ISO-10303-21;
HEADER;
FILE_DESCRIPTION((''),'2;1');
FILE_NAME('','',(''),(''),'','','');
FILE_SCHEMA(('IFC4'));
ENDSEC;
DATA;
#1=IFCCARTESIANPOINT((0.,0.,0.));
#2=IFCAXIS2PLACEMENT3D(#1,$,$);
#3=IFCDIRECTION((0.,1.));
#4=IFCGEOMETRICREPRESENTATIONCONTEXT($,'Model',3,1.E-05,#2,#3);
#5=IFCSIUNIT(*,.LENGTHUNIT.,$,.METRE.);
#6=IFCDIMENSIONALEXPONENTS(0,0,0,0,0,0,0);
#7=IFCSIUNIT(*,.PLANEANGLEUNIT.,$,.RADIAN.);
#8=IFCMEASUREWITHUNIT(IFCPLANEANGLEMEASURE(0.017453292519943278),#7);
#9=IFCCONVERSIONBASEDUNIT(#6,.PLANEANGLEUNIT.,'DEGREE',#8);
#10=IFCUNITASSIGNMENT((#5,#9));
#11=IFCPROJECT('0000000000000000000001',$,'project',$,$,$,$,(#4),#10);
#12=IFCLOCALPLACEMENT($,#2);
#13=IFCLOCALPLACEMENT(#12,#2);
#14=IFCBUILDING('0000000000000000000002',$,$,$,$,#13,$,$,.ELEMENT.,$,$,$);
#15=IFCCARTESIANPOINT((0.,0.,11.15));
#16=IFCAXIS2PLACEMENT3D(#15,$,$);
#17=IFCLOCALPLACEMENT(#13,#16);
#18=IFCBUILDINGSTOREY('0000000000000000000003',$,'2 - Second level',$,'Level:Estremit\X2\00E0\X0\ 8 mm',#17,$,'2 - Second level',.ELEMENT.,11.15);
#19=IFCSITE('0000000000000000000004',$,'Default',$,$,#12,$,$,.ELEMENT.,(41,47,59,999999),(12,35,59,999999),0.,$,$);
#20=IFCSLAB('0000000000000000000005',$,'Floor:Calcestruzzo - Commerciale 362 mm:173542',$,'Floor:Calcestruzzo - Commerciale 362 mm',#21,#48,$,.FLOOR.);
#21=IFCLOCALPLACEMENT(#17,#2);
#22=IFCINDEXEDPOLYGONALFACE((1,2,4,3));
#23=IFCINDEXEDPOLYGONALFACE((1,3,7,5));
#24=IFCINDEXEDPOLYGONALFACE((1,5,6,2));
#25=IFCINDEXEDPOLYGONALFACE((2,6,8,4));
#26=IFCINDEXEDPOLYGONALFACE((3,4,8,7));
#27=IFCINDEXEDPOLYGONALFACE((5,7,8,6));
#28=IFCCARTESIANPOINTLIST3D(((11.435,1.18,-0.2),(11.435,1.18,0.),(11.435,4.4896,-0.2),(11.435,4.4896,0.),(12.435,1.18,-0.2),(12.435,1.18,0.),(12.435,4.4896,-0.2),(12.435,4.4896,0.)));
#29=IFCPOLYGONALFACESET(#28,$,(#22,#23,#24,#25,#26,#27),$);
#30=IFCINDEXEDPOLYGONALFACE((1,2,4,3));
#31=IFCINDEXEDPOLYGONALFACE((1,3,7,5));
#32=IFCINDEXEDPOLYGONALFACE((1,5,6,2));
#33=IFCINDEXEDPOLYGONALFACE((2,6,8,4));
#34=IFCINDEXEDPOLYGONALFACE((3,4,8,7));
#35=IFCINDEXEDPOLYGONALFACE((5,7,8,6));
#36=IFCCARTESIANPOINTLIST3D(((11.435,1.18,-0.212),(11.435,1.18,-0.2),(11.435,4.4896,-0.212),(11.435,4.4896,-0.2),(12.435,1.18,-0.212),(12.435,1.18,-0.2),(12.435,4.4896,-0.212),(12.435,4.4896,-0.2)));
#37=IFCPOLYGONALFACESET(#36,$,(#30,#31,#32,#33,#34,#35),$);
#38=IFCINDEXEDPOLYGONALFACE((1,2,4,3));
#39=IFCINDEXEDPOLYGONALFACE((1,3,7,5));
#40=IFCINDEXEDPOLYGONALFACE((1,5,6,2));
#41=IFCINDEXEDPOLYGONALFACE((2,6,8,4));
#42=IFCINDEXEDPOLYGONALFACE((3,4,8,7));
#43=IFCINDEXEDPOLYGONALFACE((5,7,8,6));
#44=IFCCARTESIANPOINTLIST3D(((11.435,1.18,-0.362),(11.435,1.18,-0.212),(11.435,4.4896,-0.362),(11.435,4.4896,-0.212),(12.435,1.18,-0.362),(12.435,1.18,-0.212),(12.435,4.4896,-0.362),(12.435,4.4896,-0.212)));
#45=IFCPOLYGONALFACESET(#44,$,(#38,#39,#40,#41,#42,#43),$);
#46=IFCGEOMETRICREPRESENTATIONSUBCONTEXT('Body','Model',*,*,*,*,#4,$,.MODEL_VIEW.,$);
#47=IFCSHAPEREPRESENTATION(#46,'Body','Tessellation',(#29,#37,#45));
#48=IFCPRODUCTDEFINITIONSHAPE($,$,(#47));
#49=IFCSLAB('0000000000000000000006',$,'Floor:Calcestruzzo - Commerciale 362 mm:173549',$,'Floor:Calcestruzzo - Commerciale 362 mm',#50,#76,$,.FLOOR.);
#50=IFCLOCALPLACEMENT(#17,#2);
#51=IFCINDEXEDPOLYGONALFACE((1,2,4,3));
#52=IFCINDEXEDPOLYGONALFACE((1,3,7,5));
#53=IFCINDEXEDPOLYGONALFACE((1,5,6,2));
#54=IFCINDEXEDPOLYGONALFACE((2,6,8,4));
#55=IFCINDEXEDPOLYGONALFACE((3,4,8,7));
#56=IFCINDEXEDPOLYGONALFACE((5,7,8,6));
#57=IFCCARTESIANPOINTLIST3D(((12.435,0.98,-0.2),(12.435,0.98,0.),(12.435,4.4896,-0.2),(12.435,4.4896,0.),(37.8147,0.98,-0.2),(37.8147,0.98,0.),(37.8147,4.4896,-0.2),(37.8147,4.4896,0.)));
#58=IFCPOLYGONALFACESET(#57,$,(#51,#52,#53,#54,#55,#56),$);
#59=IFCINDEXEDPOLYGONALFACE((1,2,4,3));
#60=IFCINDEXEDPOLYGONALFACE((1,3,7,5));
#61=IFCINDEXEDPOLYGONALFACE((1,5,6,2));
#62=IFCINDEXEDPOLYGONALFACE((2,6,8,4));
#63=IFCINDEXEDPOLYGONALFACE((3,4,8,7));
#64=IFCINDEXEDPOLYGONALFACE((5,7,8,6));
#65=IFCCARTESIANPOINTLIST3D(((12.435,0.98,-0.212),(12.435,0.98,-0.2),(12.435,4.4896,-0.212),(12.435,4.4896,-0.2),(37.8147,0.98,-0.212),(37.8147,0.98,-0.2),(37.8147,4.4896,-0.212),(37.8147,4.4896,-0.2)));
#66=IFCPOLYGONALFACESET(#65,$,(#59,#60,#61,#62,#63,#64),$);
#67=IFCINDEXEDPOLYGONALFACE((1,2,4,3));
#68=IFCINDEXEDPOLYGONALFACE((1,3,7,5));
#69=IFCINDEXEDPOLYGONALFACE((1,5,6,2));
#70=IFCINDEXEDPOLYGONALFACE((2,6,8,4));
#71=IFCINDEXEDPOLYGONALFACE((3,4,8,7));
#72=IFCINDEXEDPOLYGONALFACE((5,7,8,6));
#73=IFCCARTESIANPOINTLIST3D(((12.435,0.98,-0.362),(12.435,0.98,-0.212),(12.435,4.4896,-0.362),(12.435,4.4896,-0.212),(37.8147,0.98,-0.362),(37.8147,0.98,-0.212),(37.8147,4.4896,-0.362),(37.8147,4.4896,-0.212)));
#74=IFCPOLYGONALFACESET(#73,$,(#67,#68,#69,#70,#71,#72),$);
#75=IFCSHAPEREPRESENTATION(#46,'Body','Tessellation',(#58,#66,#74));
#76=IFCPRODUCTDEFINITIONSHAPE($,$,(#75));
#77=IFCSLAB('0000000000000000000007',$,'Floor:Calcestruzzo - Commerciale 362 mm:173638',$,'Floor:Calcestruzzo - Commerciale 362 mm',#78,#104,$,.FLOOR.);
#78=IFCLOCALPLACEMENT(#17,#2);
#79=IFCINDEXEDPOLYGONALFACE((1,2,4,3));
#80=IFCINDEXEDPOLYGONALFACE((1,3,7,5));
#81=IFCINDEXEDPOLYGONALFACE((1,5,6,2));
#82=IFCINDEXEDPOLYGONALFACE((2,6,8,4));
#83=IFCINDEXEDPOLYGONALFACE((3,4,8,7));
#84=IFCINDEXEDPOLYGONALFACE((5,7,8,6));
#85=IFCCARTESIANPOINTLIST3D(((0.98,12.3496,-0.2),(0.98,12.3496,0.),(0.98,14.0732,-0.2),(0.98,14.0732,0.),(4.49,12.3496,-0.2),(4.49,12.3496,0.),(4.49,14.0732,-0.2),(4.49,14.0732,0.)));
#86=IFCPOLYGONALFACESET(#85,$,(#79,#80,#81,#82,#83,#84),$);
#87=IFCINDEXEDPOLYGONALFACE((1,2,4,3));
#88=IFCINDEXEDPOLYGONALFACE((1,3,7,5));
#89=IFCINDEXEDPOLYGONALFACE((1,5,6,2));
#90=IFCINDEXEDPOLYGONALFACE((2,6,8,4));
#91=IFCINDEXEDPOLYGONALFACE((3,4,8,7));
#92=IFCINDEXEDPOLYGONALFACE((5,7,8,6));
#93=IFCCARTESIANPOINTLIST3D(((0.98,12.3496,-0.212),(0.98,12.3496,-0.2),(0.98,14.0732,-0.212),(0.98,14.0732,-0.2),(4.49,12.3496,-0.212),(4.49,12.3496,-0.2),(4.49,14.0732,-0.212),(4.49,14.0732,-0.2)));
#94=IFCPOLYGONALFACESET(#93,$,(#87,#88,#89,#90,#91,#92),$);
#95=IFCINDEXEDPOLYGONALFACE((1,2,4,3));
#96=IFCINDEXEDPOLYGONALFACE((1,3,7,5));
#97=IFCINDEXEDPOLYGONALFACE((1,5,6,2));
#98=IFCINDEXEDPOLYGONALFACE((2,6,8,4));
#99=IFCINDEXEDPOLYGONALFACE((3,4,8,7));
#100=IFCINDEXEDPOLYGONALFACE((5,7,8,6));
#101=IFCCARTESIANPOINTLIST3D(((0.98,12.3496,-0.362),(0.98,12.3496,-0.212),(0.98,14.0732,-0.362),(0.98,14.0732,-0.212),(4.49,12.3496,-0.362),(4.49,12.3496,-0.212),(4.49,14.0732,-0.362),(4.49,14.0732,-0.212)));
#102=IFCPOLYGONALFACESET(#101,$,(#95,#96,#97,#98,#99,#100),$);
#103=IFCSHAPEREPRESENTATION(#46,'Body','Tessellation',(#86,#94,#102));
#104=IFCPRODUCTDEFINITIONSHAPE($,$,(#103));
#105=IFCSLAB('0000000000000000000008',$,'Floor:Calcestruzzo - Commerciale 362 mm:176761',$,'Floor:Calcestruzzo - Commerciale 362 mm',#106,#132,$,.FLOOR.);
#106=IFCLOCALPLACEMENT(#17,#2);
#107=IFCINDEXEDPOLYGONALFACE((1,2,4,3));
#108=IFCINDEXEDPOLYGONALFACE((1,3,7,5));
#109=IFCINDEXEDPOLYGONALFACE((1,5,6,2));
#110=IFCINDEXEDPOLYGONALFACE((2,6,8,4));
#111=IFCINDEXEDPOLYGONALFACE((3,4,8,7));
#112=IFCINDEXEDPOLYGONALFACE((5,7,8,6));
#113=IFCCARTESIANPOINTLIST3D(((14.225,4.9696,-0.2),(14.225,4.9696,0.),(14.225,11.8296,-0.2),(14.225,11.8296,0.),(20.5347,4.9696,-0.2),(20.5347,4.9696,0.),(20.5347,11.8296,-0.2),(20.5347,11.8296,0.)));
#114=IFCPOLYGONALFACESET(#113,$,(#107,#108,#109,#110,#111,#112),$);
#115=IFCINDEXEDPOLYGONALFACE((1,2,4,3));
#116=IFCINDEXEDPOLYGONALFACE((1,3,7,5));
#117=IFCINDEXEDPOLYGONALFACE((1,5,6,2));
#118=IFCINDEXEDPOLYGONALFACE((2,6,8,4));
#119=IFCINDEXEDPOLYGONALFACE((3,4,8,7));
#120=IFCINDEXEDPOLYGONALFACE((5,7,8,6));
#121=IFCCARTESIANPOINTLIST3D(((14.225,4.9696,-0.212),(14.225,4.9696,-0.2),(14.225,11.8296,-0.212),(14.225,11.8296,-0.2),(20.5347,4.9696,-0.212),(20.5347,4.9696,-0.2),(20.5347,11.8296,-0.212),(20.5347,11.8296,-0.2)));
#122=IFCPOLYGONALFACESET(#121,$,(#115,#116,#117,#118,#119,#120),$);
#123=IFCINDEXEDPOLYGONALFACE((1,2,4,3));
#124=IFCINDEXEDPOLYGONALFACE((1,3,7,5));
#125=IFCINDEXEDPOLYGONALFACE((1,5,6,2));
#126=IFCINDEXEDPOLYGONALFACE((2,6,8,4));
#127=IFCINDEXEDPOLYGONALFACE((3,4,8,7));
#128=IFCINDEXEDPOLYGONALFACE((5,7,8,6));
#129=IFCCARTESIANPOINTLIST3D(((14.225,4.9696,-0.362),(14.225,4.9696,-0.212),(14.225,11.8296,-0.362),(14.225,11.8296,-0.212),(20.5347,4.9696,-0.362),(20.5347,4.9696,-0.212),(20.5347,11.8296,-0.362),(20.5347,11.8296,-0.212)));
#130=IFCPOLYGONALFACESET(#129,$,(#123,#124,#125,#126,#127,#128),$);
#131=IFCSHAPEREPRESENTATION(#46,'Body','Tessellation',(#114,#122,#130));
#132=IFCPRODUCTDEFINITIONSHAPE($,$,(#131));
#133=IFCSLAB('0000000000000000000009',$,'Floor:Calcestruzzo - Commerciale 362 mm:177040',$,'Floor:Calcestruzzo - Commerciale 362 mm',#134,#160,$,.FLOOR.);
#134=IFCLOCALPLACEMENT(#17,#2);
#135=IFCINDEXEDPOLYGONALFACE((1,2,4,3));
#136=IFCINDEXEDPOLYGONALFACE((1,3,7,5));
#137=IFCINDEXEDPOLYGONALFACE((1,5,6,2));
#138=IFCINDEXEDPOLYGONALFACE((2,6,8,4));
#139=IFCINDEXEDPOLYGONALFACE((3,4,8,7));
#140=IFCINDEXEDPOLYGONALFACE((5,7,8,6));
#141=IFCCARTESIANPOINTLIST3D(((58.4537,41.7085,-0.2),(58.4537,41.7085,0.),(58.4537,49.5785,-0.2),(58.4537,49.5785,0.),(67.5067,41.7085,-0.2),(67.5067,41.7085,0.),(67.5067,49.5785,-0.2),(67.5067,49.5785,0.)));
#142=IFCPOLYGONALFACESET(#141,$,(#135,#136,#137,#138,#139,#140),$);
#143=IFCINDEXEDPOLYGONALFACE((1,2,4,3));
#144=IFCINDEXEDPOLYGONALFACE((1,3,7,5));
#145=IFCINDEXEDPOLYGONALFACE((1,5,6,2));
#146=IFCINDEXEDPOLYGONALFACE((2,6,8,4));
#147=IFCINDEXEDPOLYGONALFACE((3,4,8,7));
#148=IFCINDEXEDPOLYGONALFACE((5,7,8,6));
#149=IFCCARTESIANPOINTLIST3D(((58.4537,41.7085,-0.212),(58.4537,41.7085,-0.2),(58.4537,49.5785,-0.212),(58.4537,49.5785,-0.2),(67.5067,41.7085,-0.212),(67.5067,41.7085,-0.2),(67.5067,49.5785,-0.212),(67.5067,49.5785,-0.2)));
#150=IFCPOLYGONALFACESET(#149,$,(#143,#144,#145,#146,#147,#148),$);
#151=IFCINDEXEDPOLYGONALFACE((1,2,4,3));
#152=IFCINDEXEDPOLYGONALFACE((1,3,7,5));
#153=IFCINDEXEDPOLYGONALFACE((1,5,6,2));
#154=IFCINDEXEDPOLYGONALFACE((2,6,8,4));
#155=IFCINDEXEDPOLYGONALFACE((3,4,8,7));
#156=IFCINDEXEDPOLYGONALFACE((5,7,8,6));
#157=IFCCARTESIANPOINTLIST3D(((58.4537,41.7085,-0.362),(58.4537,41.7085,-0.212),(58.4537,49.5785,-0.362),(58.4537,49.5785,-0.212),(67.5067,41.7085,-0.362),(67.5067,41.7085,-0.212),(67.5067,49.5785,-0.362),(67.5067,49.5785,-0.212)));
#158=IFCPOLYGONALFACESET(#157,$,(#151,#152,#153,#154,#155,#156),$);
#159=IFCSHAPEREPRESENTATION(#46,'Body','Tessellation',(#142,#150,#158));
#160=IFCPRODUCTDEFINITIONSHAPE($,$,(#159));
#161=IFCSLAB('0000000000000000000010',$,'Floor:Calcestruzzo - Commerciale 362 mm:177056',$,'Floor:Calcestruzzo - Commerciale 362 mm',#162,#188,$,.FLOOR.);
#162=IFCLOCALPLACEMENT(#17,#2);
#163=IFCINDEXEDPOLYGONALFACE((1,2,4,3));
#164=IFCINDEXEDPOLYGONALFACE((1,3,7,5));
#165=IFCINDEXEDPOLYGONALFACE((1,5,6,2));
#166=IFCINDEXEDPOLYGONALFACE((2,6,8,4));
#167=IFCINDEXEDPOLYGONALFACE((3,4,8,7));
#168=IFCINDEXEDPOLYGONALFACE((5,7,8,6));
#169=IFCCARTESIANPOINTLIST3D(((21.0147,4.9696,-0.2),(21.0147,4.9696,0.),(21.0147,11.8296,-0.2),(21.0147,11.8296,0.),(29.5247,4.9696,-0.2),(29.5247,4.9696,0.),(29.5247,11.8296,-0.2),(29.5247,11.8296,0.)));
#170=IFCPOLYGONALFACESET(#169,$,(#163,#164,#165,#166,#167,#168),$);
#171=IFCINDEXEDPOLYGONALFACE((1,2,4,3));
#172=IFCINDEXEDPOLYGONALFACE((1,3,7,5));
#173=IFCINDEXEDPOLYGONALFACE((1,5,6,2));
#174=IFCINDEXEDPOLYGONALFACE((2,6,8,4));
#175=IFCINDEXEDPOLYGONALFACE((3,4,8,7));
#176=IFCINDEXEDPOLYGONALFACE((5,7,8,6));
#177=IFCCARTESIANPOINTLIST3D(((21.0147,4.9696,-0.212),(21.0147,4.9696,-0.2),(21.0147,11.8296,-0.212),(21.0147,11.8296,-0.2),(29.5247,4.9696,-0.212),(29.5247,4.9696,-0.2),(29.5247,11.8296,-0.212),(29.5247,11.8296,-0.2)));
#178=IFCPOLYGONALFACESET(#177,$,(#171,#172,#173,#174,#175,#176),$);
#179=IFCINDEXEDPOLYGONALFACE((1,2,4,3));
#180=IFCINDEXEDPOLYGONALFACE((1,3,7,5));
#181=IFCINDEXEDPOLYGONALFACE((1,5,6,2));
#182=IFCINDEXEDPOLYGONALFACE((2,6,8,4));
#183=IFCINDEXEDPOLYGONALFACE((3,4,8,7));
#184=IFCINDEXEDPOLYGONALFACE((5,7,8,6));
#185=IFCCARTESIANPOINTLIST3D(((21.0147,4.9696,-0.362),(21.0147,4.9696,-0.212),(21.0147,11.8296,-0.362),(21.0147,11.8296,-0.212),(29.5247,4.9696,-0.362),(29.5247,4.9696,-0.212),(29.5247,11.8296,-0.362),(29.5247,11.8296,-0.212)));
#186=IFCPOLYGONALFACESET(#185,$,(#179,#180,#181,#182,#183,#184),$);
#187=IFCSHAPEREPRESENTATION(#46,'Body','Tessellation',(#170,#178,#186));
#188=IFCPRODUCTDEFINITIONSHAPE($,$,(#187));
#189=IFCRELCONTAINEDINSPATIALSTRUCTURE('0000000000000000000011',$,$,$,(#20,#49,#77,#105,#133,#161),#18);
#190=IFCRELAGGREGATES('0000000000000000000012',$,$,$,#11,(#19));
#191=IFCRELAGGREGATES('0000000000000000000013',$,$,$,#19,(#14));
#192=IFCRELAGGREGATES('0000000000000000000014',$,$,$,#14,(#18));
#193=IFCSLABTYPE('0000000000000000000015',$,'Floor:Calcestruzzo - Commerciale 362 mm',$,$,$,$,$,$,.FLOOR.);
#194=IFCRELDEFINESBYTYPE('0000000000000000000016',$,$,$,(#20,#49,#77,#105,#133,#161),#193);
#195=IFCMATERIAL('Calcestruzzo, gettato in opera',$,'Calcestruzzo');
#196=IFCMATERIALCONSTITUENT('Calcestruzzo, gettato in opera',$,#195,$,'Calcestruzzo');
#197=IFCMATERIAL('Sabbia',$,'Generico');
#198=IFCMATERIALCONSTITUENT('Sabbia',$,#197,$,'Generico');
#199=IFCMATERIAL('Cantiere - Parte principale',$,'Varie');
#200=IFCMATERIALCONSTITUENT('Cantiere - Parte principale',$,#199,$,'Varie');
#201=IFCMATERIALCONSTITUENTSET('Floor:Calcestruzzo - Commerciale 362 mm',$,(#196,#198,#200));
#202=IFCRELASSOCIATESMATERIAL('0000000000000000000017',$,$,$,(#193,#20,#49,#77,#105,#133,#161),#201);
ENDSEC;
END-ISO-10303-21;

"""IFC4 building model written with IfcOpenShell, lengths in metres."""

from ifc_helpers import new_model, entity, si_unit, converted_unit, direction, frame, origin, place, context, subcontext, project, spatial, indexed_curve, outline, extrude, material, constituent, constituent_set, type_object, element, save


model = new_model("IFC4")

# Units and contexts
model_context = context("Model", 3, precision=1e-05, world=origin(), true_north=direction((0.0, 1.0)))
body_context = subcontext(model_context, "Body", "Model", "MODEL_VIEW")
ifc_project = project(units=[si_unit("LENGTHUNIT", "METRE"), converted_unit("PLANEANGLEUNIT", "DEGREE", entity("IfcPlaneAngleMeasure", 0.017453292519943278), si_unit("PLANEANGLEUNIT", "RADIAN"), dimensions=[0, 0, 0, 0, 0, 0, 0])], contexts=[model_context])

# Site, building, storey
site_placement = place(None, origin())
site = spatial("IfcSite", under=ifc_project, at=site_placement, Name="Default", CompositionType="ELEMENT", RefLatitude=(41, 47, 59, 999999), RefLongitude=(12, 35, 59, 999999), RefElevation=0.0)
building_placement = place(site_placement, origin())
building = spatial("IfcBuilding", under=site, at=building_placement, CompositionType="ELEMENT")
storey_placement = place(building_placement, frame((0.0, 0.0, 11.15)))
storey = spatial("IfcBuildingStorey", under=building, at=storey_placement, Name="2 - Second level", ObjectType="Level:Estremità 8 mm", LongName="2 - Second level", CompositionType="ELEMENT", Elevation=11.15)

# Slabs
ifc_material_1 = material(Name="Calcestruzzo, gettato in opera", Category="Calcestruzzo")
ifc_constituent_1 = constituent(ifc_material_1, Name="Calcestruzzo, gettato in opera", Category="Calcestruzzo")
ifc_material_2 = material(Name="Sabbia", Category="Generico")
ifc_constituent_2 = constituent(ifc_material_2, Name="Sabbia", Category="Generico")
ifc_material_3 = material(Name="Cantiere - Parte principale", Category="Varie")
ifc_constituent_3 = constituent(ifc_material_3, Name="Cantiere - Parte principale", Category="Varie")
ifc_constituent_set = constituent_set(constituents=[ifc_constituent_1, ifc_constituent_2, ifc_constituent_3], Name="Floor:Calcestruzzo - Commerciale 362 mm")
slab_type = type_object("IfcSlabType", Name="Floor:Calcestruzzo - Commerciale 362 mm", PredefinedType="FLOOR", material=ifc_constituent_set)
slab_1_placement = place(storey_placement, origin())
element("IfcSlab", 1, at=slab_1_placement, inside=storey, type_object=slab_type, material=ifc_constituent_set, Name="Floor:Calcestruzzo - Commerciale 362 mm:173542", ObjectType="Floor:Calcestruzzo - Commerciale 362 mm", PredefinedType="FLOOR", context=body_context, shape_type="SweptSolid", body=[
    extrude(outline(indexed_curve([(-1.6548, -0.5), (1.6548, -0.5), (1.6548, 0.5), (-1.6548, 0.5), (-1.6548, -0.5)], self_intersect=False)), frame((11.935, 2.8348, -0.2), z_axis=(0.0, 0.0, 1.0), x_axis=(0.0, 1.0, 0.0)), (0.0, 0.0, 1.0), 0.2),
    extrude(outline(indexed_curve([(-1.6548, -0.5), (1.6548, -0.5), (1.6548, 0.5), (-1.6548, 0.5), (-1.6548, -0.5)], self_intersect=False)), frame((11.935, 2.8348, -0.212), z_axis=(0.0, 0.0, 1.0), x_axis=(0.0, 1.0, 0.0)), (0.0, 0.0, 1.0), 0.012),
    extrude(outline(indexed_curve([(-1.6548, -0.5), (1.6548, -0.5), (1.6548, 0.5), (-1.6548, 0.5), (-1.6548, -0.5)], self_intersect=False)), frame((11.935, 2.8348, -0.362), z_axis=(0.0, 0.0, 1.0), x_axis=(0.0, 1.0, 0.0)), (0.0, 0.0, 1.0), 0.15),
])
slab_2_placement = place(storey_placement, origin())
element("IfcSlab", 2, at=slab_2_placement, inside=storey, type_object=slab_type, material=ifc_constituent_set, Name="Floor:Calcestruzzo - Commerciale 362 mm:173549", ObjectType="Floor:Calcestruzzo - Commerciale 362 mm", PredefinedType="FLOOR", context=body_context, shape_type="SweptSolid", body=[
    extrude(outline(indexed_curve([(-1.7548, -12.6898), (1.7548, -12.6898), (1.7548, 12.6898), (-1.7548, 12.6898), (-1.7548, -12.6898)], self_intersect=False)), frame((25.1249, 2.7348, -0.2), z_axis=(0.0, 0.0, 1.0), x_axis=(0.0, 1.0, 0.0)), (0.0, 0.0, 1.0), 0.2),
    extrude(outline(indexed_curve([(-1.7548, -12.6898), (1.7548, -12.6898), (1.7548, 12.6898), (-1.7548, 12.6898), (-1.7548, -12.6898)], self_intersect=False)), frame((25.1249, 2.7348, -0.212), z_axis=(0.0, 0.0, 1.0), x_axis=(0.0, 1.0, 0.0)), (0.0, 0.0, 1.0), 0.012),
    extrude(outline(indexed_curve([(-1.7548, -12.6898), (1.7548, -12.6898), (1.7548, 12.6898), (-1.7548, 12.6898), (-1.7548, -12.6898)], self_intersect=False)), frame((25.1249, 2.7348, -0.362), z_axis=(0.0, 0.0, 1.0), x_axis=(0.0, 1.0, 0.0)), (0.0, 0.0, 1.0), 0.15),
])
slab_3_placement = place(storey_placement, origin())
element("IfcSlab", 3, at=slab_3_placement, inside=storey, type_object=slab_type, material=ifc_constituent_set, Name="Floor:Calcestruzzo - Commerciale 362 mm:173638", ObjectType="Floor:Calcestruzzo - Commerciale 362 mm", PredefinedType="FLOOR", context=body_context, shape_type="SweptSolid", body=[
    extrude(outline(indexed_curve([(-0.8618, -1.755), (0.8618, -1.755), (0.8618, 1.755), (-0.8618, 1.755), (-0.8618, -1.755)], self_intersect=False)), frame((2.735, 13.2114, -0.2), z_axis=(0.0, 0.0, 1.0), x_axis=(0.0, -1.0, 0.0)), (0.0, 0.0, 1.0), 0.2),
    extrude(outline(indexed_curve([(-0.8618, -1.755), (0.8618, -1.755), (0.8618, 1.755), (-0.8618, 1.755), (-0.8618, -1.755)], self_intersect=False)), frame((2.735, 13.2114, -0.212), z_axis=(0.0, 0.0, 1.0), x_axis=(0.0, -1.0, 0.0)), (0.0, 0.0, 1.0), 0.012),
    extrude(outline(indexed_curve([(-0.8618, -1.755), (0.8618, -1.755), (0.8618, 1.755), (-0.8618, 1.755), (-0.8618, -1.755)], self_intersect=False)), frame((2.735, 13.2114, -0.362), z_axis=(0.0, 0.0, 1.0), x_axis=(0.0, -1.0, 0.0)), (0.0, 0.0, 1.0), 0.15),
])
slab_4_placement = place(storey_placement, origin())
element("IfcSlab", 4, at=slab_4_placement, inside=storey, type_object=slab_type, material=ifc_constituent_set, Name="Floor:Calcestruzzo - Commerciale 362 mm:176761", ObjectType="Floor:Calcestruzzo - Commerciale 362 mm", PredefinedType="FLOOR", context=body_context, shape_type="SweptSolid", body=[
    extrude(outline(indexed_curve([(-3.1548, -3.43), (3.1548, -3.43), (3.1548, 3.43), (-3.1548, 3.43), (-3.1548, -3.43)], self_intersect=False)), frame((17.3799, 8.3996, -0.2), z_axis=(0.0, 0.0, 1.0), x_axis=(-1.0, 0.0, 0.0)), (0.0, 0.0, 1.0), 0.2),
    extrude(outline(indexed_curve([(-3.1548, -3.43), (3.1548, -3.43), (3.1548, 3.43), (-3.1548, 3.43), (-3.1548, -3.43)], self_intersect=False)), frame((17.3799, 8.3996, -0.212), z_axis=(0.0, 0.0, 1.0), x_axis=(-1.0, 0.0, 0.0)), (0.0, 0.0, 1.0), 0.012),
    extrude(outline(indexed_curve([(-3.1548, -3.43), (3.1548, -3.43), (3.1548, 3.43), (-3.1548, 3.43), (-3.1548, -3.43)], self_intersect=False)), frame((17.3799, 8.3996, -0.362), z_axis=(0.0, 0.0, 1.0), x_axis=(-1.0, 0.0, 0.0)), (0.0, 0.0, 1.0), 0.15),
])
slab_5_placement = place(storey_placement, origin())
element("IfcSlab", 5, at=slab_5_placement, inside=storey, type_object=slab_type, material=ifc_constituent_set, Name="Floor:Calcestruzzo - Commerciale 362 mm:177040", ObjectType="Floor:Calcestruzzo - Commerciale 362 mm", PredefinedType="FLOOR", context=body_context, shape_type="SweptSolid", body=[
    extrude(outline(indexed_curve([(-4.5265, -3.935), (4.5265, -3.935), (4.5265, 3.935), (-4.5265, 3.935), (-4.5265, -3.935)], self_intersect=False)), frame((62.9802, 45.6435, -0.2)), (0.0, 0.0, 1.0), 0.2),
    extrude(outline(indexed_curve([(-4.5265, -3.935), (4.5265, -3.935), (4.5265, 3.935), (-4.5265, 3.935), (-4.5265, -3.935)], self_intersect=False)), frame((62.9802, 45.6435, -0.212)), (0.0, 0.0, 1.0), 0.012),
    extrude(outline(indexed_curve([(-4.5265, -3.935), (4.5265, -3.935), (4.5265, 3.935), (-4.5265, 3.935), (-4.5265, -3.935)], self_intersect=False)), frame((62.9802, 45.6435, -0.362)), (0.0, 0.0, 1.0), 0.15),
])
slab_6_placement = place(storey_placement, origin())
element("IfcSlab", 6, at=slab_6_placement, inside=storey, type_object=slab_type, material=ifc_constituent_set, Name="Floor:Calcestruzzo - Commerciale 362 mm:177056", ObjectType="Floor:Calcestruzzo - Commerciale 362 mm", PredefinedType="FLOOR", context=body_context, shape_type="SweptSolid", body=[
    extrude(outline(indexed_curve([(-3.43, -4.255), (3.43, -4.255), (3.43, 4.255), (-3.43, 4.255), (-3.43, -4.255)], self_intersect=False)), frame((25.2697, 8.3996, -0.2), z_axis=(0.0, 0.0, 1.0), x_axis=(0.0, 1.0, 0.0)), (0.0, 0.0, 1.0), 0.2),
    extrude(outline(indexed_curve([(-3.43, -4.255), (3.43, -4.255), (3.43, 4.255), (-3.43, 4.255), (-3.43, -4.255)], self_intersect=False)), frame((25.2697, 8.3996, -0.212), z_axis=(0.0, 0.0, 1.0), x_axis=(0.0, 1.0, 0.0)), (0.0, 0.0, 1.0), 0.012),
    extrude(outline(indexed_curve([(-3.43, -4.255), (3.43, -4.255), (3.43, 4.255), (-3.43, 4.255), (-3.43, -4.255)], self_intersect=False)), frame((25.2697, 8.3996, -0.362), z_axis=(0.0, 0.0, 1.0), x_axis=(0.0, 1.0, 0.0)), (0.0, 0.0, 1.0), 0.15),
])

save(model, "model.ifc")
